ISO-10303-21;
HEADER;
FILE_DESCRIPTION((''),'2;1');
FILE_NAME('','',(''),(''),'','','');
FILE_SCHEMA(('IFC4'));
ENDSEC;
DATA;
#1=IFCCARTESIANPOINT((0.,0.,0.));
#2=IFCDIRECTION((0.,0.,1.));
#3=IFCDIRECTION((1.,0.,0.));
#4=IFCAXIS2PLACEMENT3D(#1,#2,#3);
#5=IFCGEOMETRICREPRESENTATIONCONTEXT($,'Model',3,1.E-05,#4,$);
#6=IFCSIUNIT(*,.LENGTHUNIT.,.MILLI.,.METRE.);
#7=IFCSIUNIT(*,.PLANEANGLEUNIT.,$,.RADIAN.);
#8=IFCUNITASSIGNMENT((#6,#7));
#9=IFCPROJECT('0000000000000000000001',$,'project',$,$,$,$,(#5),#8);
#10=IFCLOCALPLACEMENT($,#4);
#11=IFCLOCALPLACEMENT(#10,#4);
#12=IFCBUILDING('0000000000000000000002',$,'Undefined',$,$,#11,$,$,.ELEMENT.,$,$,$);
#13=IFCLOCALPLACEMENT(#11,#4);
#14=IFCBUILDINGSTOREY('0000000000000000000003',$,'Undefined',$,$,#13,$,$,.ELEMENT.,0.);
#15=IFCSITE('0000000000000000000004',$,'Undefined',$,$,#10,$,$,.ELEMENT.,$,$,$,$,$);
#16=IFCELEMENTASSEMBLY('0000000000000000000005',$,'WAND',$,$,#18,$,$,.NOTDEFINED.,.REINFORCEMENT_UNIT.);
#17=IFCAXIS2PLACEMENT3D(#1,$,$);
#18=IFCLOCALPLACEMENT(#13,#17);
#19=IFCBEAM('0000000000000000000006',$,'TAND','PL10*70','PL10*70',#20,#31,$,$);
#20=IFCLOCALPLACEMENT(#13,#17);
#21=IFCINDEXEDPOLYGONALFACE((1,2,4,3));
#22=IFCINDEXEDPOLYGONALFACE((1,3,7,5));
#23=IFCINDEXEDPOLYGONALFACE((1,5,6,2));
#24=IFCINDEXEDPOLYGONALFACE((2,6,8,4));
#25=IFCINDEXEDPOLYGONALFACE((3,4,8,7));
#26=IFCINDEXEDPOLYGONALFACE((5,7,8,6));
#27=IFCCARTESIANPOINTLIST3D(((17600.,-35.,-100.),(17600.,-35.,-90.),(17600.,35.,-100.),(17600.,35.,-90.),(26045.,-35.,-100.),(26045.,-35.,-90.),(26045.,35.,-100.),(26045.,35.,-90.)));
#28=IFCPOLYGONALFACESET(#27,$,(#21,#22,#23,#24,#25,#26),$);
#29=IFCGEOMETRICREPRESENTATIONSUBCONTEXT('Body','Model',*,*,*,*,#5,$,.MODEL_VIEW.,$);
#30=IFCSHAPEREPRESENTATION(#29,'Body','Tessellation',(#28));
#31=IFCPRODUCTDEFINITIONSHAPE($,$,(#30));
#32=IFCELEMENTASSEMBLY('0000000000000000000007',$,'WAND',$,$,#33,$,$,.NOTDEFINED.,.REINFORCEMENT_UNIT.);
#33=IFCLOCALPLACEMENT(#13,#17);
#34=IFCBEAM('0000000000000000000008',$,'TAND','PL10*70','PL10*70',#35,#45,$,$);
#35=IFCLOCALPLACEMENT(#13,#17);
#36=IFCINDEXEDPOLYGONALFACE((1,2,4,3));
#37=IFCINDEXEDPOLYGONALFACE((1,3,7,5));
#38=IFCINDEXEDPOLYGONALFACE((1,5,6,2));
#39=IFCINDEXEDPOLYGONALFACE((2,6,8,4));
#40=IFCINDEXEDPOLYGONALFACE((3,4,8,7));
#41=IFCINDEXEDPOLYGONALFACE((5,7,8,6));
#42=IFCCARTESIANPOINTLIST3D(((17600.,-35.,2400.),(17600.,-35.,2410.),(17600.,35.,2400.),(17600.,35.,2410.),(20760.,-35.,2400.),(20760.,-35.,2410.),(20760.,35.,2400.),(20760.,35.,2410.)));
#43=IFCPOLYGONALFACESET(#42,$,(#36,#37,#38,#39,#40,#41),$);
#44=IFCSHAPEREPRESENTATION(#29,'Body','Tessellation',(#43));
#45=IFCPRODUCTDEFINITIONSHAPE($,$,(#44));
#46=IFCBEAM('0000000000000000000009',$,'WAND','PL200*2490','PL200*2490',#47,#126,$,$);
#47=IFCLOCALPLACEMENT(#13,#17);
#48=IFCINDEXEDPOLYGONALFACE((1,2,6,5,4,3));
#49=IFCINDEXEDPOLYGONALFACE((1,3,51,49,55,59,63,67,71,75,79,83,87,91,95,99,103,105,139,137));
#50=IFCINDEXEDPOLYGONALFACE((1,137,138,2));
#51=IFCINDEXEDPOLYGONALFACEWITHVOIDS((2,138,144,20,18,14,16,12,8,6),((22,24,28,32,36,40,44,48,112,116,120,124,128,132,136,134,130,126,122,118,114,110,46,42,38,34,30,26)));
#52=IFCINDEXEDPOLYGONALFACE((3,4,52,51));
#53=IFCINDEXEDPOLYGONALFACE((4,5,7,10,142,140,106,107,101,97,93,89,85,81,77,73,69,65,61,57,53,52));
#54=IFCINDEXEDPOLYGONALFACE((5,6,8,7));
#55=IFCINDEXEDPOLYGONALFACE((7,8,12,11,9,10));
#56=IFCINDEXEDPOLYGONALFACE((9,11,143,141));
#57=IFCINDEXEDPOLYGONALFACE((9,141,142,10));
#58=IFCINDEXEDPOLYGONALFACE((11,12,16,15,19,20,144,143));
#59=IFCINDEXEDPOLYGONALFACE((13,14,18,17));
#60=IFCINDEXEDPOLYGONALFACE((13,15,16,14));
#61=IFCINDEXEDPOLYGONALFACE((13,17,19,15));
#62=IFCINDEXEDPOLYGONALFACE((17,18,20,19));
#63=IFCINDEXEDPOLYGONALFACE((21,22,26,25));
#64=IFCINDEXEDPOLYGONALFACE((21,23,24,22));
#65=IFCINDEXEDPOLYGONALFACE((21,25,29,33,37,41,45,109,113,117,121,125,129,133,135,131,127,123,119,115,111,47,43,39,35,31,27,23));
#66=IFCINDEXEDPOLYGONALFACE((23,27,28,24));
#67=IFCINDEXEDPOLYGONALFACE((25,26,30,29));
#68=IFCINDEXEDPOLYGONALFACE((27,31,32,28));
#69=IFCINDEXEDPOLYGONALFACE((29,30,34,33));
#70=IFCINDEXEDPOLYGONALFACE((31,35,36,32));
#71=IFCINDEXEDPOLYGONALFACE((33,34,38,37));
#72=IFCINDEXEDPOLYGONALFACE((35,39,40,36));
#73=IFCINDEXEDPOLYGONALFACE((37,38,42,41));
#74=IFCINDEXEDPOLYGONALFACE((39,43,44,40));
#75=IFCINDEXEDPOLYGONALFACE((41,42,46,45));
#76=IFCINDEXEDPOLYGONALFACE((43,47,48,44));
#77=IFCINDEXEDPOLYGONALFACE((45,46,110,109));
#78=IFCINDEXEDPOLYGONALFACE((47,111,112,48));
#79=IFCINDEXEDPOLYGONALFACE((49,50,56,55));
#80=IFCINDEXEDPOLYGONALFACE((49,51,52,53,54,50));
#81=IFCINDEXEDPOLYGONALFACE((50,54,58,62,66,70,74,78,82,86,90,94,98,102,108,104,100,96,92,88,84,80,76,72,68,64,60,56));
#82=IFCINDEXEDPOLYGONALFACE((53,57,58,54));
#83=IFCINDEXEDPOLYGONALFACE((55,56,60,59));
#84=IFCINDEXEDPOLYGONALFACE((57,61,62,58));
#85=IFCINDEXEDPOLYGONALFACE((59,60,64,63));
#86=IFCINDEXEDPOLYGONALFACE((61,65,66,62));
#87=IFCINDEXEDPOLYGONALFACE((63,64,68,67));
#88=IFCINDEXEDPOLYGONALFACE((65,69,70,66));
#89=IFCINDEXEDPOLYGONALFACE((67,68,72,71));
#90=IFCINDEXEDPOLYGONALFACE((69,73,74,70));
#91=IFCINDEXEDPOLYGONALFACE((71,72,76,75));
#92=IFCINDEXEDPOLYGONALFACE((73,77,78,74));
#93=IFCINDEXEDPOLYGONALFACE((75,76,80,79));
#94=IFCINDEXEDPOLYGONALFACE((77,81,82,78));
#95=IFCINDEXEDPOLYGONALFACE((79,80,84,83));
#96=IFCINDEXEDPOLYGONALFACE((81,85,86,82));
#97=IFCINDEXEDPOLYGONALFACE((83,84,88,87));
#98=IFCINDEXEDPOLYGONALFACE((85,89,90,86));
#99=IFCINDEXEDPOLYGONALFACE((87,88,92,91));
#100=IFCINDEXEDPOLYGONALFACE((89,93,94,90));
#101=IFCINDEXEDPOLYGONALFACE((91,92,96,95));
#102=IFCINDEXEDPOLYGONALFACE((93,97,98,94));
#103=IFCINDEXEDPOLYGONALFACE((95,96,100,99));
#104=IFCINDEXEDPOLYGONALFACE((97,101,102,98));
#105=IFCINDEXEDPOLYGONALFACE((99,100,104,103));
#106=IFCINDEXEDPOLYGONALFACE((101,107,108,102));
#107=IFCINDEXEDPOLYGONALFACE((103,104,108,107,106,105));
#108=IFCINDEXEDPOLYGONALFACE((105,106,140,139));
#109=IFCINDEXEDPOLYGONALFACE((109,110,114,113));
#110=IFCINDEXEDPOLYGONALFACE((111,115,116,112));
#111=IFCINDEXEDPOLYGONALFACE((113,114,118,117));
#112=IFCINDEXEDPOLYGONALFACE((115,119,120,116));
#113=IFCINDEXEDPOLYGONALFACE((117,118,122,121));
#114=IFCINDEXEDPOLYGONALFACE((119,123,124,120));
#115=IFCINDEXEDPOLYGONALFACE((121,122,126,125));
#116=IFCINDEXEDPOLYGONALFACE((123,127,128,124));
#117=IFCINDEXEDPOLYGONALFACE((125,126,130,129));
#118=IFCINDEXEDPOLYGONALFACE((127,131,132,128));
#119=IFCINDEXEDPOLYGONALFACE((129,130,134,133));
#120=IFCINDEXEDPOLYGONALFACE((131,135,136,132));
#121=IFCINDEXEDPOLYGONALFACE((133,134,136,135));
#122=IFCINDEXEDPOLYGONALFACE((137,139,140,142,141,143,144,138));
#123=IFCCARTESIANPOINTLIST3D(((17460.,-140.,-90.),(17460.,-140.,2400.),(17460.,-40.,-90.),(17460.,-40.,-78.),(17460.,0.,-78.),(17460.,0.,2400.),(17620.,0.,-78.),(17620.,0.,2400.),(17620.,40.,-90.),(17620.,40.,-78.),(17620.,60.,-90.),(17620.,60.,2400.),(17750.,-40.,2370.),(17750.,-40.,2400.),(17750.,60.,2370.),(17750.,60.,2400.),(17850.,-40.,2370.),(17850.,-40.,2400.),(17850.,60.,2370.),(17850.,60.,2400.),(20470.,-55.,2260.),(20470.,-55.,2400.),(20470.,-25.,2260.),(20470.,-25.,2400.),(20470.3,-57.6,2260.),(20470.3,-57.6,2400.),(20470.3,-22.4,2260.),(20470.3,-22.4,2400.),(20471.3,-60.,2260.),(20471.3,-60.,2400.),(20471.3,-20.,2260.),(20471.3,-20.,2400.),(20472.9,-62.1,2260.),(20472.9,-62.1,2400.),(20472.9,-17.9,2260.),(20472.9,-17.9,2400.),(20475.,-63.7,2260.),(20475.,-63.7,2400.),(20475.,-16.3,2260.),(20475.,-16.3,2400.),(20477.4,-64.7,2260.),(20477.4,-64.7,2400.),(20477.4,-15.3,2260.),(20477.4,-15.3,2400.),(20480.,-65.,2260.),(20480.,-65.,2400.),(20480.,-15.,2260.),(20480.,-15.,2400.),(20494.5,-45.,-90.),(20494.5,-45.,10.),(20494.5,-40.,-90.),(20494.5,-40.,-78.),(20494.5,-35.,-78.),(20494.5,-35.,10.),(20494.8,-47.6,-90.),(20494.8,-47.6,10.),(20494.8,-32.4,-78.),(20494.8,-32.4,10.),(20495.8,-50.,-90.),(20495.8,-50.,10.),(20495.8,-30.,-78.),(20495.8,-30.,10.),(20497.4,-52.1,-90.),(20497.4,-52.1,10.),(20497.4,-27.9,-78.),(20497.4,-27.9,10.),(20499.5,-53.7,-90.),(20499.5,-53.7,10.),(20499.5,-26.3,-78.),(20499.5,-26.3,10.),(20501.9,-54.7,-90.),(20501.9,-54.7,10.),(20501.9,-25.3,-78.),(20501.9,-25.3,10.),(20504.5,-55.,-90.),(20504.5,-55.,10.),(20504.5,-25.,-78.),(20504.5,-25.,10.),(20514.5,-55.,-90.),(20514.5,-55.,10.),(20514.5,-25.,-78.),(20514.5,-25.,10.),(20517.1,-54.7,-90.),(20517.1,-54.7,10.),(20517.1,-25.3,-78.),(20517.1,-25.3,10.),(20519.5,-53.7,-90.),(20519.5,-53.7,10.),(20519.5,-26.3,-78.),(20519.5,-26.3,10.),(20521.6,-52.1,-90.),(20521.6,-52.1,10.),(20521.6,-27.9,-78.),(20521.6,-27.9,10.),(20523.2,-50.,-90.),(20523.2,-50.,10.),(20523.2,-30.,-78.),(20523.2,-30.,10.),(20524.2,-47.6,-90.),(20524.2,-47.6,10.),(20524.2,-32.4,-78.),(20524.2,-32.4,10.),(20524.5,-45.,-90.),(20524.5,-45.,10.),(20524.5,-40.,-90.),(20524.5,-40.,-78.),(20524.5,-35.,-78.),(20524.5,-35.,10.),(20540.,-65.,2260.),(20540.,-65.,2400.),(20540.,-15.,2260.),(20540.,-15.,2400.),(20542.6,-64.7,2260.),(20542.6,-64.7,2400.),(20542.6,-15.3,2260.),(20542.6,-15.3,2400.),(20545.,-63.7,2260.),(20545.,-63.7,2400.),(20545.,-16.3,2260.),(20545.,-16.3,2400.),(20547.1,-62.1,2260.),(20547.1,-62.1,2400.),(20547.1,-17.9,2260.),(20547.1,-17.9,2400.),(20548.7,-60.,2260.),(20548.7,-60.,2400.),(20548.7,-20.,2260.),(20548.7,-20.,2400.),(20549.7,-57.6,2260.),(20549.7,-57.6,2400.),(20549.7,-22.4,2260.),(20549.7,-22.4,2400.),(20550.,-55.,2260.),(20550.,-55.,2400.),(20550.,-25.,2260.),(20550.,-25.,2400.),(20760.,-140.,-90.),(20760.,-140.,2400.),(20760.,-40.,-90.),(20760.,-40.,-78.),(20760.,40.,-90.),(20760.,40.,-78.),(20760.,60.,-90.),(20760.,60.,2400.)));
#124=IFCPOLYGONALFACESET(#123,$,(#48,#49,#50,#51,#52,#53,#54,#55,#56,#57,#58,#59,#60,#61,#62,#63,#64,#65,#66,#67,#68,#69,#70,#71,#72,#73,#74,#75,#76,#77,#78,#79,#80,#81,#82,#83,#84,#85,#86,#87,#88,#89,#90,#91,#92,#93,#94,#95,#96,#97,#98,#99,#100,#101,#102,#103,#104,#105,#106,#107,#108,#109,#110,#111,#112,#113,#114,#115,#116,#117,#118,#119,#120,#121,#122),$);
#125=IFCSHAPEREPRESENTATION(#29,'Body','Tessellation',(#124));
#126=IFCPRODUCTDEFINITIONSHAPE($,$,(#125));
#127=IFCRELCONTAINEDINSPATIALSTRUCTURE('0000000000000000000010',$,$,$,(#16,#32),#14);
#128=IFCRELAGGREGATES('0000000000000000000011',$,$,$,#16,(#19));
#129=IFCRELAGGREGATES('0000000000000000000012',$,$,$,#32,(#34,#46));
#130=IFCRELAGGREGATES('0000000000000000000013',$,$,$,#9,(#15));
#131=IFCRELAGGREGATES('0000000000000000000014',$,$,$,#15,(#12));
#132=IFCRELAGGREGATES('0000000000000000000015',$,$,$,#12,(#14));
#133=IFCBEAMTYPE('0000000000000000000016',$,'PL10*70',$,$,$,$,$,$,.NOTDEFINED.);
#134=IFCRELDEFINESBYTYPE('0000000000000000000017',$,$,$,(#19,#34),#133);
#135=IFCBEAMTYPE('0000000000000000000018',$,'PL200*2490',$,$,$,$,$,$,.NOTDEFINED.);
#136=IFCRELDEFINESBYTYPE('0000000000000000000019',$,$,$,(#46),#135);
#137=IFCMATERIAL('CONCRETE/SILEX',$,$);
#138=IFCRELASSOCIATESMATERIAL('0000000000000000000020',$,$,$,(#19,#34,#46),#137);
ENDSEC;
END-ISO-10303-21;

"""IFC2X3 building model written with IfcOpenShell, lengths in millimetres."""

from ifc_helpers import new_model, si_unit, frame, frame_2d, origin_with_axes, place, context, subcontext, project, spatial, polyline, circle_curve, parameter, trimmed, segment, composite_curve, rectangle, outline, extrude, boolean, material, type_object, element, aggregate, save


model = new_model("IFC2X3")

# Units and contexts
model_context = context("Model", 3, precision=1e-05, world=origin_with_axes())
body_context = subcontext(model_context, "Body", "Model", "MODEL_VIEW")
ifc_project = project(units=[si_unit("LENGTHUNIT", "METRE", prefix="MILLI"), si_unit("PLANEANGLEUNIT", "RADIAN")], contexts=[model_context])

# Site, building, storey
site_placement = place(None, origin_with_axes())
site = spatial("IfcSite", under=ifc_project, at=site_placement, Name="Undefined", CompositionType="ELEMENT")
building_placement = place(site_placement, origin_with_axes())
building = spatial("IfcBuilding", under=site, at=building_placement, Name="Undefined", CompositionType="ELEMENT")
storey_placement = place(building_placement, origin_with_axes())
storey = spatial("IfcBuildingStorey", under=building, at=storey_placement, Name="Undefined", CompositionType="ELEMENT", Elevation=0.0)

# Element assembly, beam
assembly_1_placement = place(storey_placement, origin_with_axes())
assembly_1 = element("IfcElementAssembly", 1, at=assembly_1_placement, inside=storey, Name="WAND", AssemblyPlace="NOTDEFINED", PredefinedType="REINFORCEMENT_UNIT")
ifc_material_1 = material(Name="CONCRETE/SILEX")
beam_type_1 = type_object("IfcBeamType", Name="PL10*70", PredefinedType="NOTDEFINED")
beam_1_placement = place(assembly_1_placement, frame((17600.0, 0.0, -95.0), z_axis=(0.0, -1.0, 0.0), x_axis=(1.0, 0.0, 0.0)))
beam_1 = element("IfcBeam", 2, at=beam_1_placement, type_object=beam_type_1, material=ifc_material_1, Name="TAND", Description="PL10*70", ObjectType="PL10*70", context=body_context, shape_type="SweptSolid", body=[
    extrude(rectangle(XDim=10.0, YDim=70.0, at=frame_2d((0.0, 0.0), x_axis=(1.0, 0.0))), frame((8445.0, 0.0, 0.0), z_axis=(-1.0, 0.0, 0.0), x_axis=(0.0, -1.0, 0.0)), (0.0, 0.0, 1.0), 8445.0),
])

# Element assembly, beams
assembly_2_placement = place(storey_placement, origin_with_axes())
assembly_2 = element("IfcElementAssembly", 3, at=assembly_2_placement, inside=storey, Name="WAND", AssemblyPlace="NOTDEFINED", PredefinedType="REINFORCEMENT_UNIT")
beam_2_placement = place(assembly_2_placement, frame((17600.0, 0.0, 2405.0), z_axis=(0.0, -1.0, 0.0), x_axis=(1.0, 0.0, 0.0)))
beam_2 = element("IfcBeam", 4, at=beam_2_placement, type_object=beam_type_1, material=ifc_material_1, Name="TAND", Description="PL10*70", ObjectType="PL10*70", context=body_context, shape_type="SweptSolid", body=[
    extrude(rectangle(XDim=10.0, YDim=70.0, at=frame_2d((0.0, 0.0), x_axis=(1.0, 0.0))), frame((3160.0, 0.0, 0.0), z_axis=(-1.0, 0.0, 0.0), x_axis=(0.0, -1.0, 0.0)), (0.0, 0.0, 1.0), 3160.0),
])
beam_type_2 = type_object("IfcBeamType", Name="PL200*2490", PredefinedType="NOTDEFINED")
beam_3_placement = place(assembly_2_placement, frame((17460.0, -40.0, 1155.0), z_axis=(0.0, 0.0, 1.0), x_axis=(1.0, 0.0, 0.0)))
beam_3 = element("IfcBeam", 5, at=beam_3_placement, type_object=beam_type_2, material=ifc_material_1, Name="WAND", Description="PL200*2490", ObjectType="PL200*2490", context=body_context, shape_type="CSG", body=[
    boolean("DIFFERENCE", boolean("DIFFERENCE", boolean("DIFFERENCE", boolean("DIFFERENCE", boolean("DIFFERENCE", extrude(rectangle(XDim=200.0, YDim=2490.0, at=frame_2d((0.0, 0.0), x_axis=(1.0, 0.0))), frame((3300.0, 0.0, 0.0), z_axis=(-1.0, 0.0, 0.0), x_axis=(0.0, -1.0, 0.0)), (0.0, 0.0, 1.0), 3300.0), extrude(outline(composite_curve([segment(trimmed(circle_curve(frame_2d((10.0, 10.0), x_axis=(-1.0, 0.0)), 10.0), [parameter(0.0)], [parameter(1.570796)], True, "PARAMETER"), True, "CONTINUOUS"), segment(polyline([(10.0, 0.0), (40.0, 0.0)]), True, "CONTINUOUS"), segment(trimmed(circle_curve(frame_2d((40.0, 10.0), x_axis=(0.0, -1.0)), 10.0), [parameter(0.0)], [parameter(1.570796)], True, "PARAMETER"), True, "CONTINUOUS"), segment(polyline([(50.0, 10.0), (50.0, 70.0)]), True, "CONTINUOUS"), segment(trimmed(circle_curve(frame_2d((40.0, 70.0), x_axis=(1.0, 0.0)), 10.0), [parameter(0.0)], [parameter(1.570796)], True, "PARAMETER"), True, "CONTINUOUS"), segment(polyline([(40.0, 80.0), (10.0, 80.0)]), True, "CONTINUOUS"), segment(trimmed(circle_curve(frame_2d((10.0, 70.0), x_axis=(0.0, 1.0)), 10.0), [parameter(0.0)], [parameter(1.570796)], True, "PARAMETER"), True, "CONTINUOUS"), segment(polyline([(0.0, 70.0), (0.0, 10.0)]), True, "CONTINUOUS")], self_intersect=True)), frame((3010.0, 25.0, 1105.0), z_axis=(0.0, 0.0, 1.0), x_axis=(0.0, -1.0, 0.0)), (0.0, 0.0, 1.0), 150.0)), extrude(outline(composite_curve([segment(trimmed(circle_curve(frame_2d((10.0, 10.0), x_axis=(-1.0, 0.0)), 10.0), [parameter(0.0)], [parameter(1.570796)], True, "PARAMETER"), True, "CONTINUOUS"), segment(polyline([(10.0, 0.0), (20.0, 0.0)]), True, "CONTINUOUS"), segment(trimmed(circle_curve(frame_2d((20.0, 10.0), x_axis=(0.0, -1.0)), 10.0), [parameter(0.0)], [parameter(1.570796)], True, "PARAMETER"), True, "CONTINUOUS"), segment(polyline([(30.0, 10.0), (30.0, 20.0)]), True, "CONTINUOUS"), segment(trimmed(circle_curve(frame_2d((20.0, 20.0), x_axis=(1.0, 0.0)), 10.0), [parameter(0.0)], [parameter(1.570796)], True, "PARAMETER"), True, "CONTINUOUS"), segment(polyline([(20.0, 30.0), (10.0, 30.0)]), True, "CONTINUOUS"), segment(trimmed(circle_curve(frame_2d((10.0, 20.0), x_axis=(0.0, 1.0)), 10.0), [parameter(0.0)], [parameter(1.570796)], True, "PARAMETER"), True, "CONTINUOUS"), segment(polyline([(0.0, 20.0), (0.0, 10.0)]), True, "CONTINUOUS")], self_intersect=True)), frame((3064.5, -15.0, -1245.0), z_axis=(0.0, 0.0, 1.0), x_axis=(0.0, 1.0, 0.0)), (0.0, 0.0, 1.0), 100.0)), extrude(outline(polyline([(0.0, 0.0), (60.0, 0.0), (60.0, 185.3), (0.0, 185.3), (0.0, 0.0)])), frame((160.0, 100.0, 1757.5), z_axis=(0.0, 0.0, -1.0), x_axis=(0.0, -1.0, 0.0)), (0.0, 0.0, 1.0), 3005.0)), extrude(rectangle(XDim=100.0, YDim=100.0, at=frame_2d((0.0, 0.0), x_axis=(1.0, 0.0))), frame((340.0, 50.0, 1215.0), z_axis=(0.0, 0.0, 1.0), x_axis=(-1.0, 0.0, 0.0)), (0.0, 0.0, 1.0), 30.0)), extrude(rectangle(XDim=12.0, YDim=80.0, at=frame_2d((0.0, 0.0), x_axis=(1.0, 0.0))), frame((8585.0, 40.0, -1239.0), z_axis=(-1.0, 0.0, 0.0), x_axis=(0.0, 0.0, -1.0)), (0.0, 0.0, 1.0), 8585.0)),
])

aggregate(assembly_1, [beam_1])

aggregate(assembly_2, [beam_2, beam_3])

save(model, "model.ifc")
